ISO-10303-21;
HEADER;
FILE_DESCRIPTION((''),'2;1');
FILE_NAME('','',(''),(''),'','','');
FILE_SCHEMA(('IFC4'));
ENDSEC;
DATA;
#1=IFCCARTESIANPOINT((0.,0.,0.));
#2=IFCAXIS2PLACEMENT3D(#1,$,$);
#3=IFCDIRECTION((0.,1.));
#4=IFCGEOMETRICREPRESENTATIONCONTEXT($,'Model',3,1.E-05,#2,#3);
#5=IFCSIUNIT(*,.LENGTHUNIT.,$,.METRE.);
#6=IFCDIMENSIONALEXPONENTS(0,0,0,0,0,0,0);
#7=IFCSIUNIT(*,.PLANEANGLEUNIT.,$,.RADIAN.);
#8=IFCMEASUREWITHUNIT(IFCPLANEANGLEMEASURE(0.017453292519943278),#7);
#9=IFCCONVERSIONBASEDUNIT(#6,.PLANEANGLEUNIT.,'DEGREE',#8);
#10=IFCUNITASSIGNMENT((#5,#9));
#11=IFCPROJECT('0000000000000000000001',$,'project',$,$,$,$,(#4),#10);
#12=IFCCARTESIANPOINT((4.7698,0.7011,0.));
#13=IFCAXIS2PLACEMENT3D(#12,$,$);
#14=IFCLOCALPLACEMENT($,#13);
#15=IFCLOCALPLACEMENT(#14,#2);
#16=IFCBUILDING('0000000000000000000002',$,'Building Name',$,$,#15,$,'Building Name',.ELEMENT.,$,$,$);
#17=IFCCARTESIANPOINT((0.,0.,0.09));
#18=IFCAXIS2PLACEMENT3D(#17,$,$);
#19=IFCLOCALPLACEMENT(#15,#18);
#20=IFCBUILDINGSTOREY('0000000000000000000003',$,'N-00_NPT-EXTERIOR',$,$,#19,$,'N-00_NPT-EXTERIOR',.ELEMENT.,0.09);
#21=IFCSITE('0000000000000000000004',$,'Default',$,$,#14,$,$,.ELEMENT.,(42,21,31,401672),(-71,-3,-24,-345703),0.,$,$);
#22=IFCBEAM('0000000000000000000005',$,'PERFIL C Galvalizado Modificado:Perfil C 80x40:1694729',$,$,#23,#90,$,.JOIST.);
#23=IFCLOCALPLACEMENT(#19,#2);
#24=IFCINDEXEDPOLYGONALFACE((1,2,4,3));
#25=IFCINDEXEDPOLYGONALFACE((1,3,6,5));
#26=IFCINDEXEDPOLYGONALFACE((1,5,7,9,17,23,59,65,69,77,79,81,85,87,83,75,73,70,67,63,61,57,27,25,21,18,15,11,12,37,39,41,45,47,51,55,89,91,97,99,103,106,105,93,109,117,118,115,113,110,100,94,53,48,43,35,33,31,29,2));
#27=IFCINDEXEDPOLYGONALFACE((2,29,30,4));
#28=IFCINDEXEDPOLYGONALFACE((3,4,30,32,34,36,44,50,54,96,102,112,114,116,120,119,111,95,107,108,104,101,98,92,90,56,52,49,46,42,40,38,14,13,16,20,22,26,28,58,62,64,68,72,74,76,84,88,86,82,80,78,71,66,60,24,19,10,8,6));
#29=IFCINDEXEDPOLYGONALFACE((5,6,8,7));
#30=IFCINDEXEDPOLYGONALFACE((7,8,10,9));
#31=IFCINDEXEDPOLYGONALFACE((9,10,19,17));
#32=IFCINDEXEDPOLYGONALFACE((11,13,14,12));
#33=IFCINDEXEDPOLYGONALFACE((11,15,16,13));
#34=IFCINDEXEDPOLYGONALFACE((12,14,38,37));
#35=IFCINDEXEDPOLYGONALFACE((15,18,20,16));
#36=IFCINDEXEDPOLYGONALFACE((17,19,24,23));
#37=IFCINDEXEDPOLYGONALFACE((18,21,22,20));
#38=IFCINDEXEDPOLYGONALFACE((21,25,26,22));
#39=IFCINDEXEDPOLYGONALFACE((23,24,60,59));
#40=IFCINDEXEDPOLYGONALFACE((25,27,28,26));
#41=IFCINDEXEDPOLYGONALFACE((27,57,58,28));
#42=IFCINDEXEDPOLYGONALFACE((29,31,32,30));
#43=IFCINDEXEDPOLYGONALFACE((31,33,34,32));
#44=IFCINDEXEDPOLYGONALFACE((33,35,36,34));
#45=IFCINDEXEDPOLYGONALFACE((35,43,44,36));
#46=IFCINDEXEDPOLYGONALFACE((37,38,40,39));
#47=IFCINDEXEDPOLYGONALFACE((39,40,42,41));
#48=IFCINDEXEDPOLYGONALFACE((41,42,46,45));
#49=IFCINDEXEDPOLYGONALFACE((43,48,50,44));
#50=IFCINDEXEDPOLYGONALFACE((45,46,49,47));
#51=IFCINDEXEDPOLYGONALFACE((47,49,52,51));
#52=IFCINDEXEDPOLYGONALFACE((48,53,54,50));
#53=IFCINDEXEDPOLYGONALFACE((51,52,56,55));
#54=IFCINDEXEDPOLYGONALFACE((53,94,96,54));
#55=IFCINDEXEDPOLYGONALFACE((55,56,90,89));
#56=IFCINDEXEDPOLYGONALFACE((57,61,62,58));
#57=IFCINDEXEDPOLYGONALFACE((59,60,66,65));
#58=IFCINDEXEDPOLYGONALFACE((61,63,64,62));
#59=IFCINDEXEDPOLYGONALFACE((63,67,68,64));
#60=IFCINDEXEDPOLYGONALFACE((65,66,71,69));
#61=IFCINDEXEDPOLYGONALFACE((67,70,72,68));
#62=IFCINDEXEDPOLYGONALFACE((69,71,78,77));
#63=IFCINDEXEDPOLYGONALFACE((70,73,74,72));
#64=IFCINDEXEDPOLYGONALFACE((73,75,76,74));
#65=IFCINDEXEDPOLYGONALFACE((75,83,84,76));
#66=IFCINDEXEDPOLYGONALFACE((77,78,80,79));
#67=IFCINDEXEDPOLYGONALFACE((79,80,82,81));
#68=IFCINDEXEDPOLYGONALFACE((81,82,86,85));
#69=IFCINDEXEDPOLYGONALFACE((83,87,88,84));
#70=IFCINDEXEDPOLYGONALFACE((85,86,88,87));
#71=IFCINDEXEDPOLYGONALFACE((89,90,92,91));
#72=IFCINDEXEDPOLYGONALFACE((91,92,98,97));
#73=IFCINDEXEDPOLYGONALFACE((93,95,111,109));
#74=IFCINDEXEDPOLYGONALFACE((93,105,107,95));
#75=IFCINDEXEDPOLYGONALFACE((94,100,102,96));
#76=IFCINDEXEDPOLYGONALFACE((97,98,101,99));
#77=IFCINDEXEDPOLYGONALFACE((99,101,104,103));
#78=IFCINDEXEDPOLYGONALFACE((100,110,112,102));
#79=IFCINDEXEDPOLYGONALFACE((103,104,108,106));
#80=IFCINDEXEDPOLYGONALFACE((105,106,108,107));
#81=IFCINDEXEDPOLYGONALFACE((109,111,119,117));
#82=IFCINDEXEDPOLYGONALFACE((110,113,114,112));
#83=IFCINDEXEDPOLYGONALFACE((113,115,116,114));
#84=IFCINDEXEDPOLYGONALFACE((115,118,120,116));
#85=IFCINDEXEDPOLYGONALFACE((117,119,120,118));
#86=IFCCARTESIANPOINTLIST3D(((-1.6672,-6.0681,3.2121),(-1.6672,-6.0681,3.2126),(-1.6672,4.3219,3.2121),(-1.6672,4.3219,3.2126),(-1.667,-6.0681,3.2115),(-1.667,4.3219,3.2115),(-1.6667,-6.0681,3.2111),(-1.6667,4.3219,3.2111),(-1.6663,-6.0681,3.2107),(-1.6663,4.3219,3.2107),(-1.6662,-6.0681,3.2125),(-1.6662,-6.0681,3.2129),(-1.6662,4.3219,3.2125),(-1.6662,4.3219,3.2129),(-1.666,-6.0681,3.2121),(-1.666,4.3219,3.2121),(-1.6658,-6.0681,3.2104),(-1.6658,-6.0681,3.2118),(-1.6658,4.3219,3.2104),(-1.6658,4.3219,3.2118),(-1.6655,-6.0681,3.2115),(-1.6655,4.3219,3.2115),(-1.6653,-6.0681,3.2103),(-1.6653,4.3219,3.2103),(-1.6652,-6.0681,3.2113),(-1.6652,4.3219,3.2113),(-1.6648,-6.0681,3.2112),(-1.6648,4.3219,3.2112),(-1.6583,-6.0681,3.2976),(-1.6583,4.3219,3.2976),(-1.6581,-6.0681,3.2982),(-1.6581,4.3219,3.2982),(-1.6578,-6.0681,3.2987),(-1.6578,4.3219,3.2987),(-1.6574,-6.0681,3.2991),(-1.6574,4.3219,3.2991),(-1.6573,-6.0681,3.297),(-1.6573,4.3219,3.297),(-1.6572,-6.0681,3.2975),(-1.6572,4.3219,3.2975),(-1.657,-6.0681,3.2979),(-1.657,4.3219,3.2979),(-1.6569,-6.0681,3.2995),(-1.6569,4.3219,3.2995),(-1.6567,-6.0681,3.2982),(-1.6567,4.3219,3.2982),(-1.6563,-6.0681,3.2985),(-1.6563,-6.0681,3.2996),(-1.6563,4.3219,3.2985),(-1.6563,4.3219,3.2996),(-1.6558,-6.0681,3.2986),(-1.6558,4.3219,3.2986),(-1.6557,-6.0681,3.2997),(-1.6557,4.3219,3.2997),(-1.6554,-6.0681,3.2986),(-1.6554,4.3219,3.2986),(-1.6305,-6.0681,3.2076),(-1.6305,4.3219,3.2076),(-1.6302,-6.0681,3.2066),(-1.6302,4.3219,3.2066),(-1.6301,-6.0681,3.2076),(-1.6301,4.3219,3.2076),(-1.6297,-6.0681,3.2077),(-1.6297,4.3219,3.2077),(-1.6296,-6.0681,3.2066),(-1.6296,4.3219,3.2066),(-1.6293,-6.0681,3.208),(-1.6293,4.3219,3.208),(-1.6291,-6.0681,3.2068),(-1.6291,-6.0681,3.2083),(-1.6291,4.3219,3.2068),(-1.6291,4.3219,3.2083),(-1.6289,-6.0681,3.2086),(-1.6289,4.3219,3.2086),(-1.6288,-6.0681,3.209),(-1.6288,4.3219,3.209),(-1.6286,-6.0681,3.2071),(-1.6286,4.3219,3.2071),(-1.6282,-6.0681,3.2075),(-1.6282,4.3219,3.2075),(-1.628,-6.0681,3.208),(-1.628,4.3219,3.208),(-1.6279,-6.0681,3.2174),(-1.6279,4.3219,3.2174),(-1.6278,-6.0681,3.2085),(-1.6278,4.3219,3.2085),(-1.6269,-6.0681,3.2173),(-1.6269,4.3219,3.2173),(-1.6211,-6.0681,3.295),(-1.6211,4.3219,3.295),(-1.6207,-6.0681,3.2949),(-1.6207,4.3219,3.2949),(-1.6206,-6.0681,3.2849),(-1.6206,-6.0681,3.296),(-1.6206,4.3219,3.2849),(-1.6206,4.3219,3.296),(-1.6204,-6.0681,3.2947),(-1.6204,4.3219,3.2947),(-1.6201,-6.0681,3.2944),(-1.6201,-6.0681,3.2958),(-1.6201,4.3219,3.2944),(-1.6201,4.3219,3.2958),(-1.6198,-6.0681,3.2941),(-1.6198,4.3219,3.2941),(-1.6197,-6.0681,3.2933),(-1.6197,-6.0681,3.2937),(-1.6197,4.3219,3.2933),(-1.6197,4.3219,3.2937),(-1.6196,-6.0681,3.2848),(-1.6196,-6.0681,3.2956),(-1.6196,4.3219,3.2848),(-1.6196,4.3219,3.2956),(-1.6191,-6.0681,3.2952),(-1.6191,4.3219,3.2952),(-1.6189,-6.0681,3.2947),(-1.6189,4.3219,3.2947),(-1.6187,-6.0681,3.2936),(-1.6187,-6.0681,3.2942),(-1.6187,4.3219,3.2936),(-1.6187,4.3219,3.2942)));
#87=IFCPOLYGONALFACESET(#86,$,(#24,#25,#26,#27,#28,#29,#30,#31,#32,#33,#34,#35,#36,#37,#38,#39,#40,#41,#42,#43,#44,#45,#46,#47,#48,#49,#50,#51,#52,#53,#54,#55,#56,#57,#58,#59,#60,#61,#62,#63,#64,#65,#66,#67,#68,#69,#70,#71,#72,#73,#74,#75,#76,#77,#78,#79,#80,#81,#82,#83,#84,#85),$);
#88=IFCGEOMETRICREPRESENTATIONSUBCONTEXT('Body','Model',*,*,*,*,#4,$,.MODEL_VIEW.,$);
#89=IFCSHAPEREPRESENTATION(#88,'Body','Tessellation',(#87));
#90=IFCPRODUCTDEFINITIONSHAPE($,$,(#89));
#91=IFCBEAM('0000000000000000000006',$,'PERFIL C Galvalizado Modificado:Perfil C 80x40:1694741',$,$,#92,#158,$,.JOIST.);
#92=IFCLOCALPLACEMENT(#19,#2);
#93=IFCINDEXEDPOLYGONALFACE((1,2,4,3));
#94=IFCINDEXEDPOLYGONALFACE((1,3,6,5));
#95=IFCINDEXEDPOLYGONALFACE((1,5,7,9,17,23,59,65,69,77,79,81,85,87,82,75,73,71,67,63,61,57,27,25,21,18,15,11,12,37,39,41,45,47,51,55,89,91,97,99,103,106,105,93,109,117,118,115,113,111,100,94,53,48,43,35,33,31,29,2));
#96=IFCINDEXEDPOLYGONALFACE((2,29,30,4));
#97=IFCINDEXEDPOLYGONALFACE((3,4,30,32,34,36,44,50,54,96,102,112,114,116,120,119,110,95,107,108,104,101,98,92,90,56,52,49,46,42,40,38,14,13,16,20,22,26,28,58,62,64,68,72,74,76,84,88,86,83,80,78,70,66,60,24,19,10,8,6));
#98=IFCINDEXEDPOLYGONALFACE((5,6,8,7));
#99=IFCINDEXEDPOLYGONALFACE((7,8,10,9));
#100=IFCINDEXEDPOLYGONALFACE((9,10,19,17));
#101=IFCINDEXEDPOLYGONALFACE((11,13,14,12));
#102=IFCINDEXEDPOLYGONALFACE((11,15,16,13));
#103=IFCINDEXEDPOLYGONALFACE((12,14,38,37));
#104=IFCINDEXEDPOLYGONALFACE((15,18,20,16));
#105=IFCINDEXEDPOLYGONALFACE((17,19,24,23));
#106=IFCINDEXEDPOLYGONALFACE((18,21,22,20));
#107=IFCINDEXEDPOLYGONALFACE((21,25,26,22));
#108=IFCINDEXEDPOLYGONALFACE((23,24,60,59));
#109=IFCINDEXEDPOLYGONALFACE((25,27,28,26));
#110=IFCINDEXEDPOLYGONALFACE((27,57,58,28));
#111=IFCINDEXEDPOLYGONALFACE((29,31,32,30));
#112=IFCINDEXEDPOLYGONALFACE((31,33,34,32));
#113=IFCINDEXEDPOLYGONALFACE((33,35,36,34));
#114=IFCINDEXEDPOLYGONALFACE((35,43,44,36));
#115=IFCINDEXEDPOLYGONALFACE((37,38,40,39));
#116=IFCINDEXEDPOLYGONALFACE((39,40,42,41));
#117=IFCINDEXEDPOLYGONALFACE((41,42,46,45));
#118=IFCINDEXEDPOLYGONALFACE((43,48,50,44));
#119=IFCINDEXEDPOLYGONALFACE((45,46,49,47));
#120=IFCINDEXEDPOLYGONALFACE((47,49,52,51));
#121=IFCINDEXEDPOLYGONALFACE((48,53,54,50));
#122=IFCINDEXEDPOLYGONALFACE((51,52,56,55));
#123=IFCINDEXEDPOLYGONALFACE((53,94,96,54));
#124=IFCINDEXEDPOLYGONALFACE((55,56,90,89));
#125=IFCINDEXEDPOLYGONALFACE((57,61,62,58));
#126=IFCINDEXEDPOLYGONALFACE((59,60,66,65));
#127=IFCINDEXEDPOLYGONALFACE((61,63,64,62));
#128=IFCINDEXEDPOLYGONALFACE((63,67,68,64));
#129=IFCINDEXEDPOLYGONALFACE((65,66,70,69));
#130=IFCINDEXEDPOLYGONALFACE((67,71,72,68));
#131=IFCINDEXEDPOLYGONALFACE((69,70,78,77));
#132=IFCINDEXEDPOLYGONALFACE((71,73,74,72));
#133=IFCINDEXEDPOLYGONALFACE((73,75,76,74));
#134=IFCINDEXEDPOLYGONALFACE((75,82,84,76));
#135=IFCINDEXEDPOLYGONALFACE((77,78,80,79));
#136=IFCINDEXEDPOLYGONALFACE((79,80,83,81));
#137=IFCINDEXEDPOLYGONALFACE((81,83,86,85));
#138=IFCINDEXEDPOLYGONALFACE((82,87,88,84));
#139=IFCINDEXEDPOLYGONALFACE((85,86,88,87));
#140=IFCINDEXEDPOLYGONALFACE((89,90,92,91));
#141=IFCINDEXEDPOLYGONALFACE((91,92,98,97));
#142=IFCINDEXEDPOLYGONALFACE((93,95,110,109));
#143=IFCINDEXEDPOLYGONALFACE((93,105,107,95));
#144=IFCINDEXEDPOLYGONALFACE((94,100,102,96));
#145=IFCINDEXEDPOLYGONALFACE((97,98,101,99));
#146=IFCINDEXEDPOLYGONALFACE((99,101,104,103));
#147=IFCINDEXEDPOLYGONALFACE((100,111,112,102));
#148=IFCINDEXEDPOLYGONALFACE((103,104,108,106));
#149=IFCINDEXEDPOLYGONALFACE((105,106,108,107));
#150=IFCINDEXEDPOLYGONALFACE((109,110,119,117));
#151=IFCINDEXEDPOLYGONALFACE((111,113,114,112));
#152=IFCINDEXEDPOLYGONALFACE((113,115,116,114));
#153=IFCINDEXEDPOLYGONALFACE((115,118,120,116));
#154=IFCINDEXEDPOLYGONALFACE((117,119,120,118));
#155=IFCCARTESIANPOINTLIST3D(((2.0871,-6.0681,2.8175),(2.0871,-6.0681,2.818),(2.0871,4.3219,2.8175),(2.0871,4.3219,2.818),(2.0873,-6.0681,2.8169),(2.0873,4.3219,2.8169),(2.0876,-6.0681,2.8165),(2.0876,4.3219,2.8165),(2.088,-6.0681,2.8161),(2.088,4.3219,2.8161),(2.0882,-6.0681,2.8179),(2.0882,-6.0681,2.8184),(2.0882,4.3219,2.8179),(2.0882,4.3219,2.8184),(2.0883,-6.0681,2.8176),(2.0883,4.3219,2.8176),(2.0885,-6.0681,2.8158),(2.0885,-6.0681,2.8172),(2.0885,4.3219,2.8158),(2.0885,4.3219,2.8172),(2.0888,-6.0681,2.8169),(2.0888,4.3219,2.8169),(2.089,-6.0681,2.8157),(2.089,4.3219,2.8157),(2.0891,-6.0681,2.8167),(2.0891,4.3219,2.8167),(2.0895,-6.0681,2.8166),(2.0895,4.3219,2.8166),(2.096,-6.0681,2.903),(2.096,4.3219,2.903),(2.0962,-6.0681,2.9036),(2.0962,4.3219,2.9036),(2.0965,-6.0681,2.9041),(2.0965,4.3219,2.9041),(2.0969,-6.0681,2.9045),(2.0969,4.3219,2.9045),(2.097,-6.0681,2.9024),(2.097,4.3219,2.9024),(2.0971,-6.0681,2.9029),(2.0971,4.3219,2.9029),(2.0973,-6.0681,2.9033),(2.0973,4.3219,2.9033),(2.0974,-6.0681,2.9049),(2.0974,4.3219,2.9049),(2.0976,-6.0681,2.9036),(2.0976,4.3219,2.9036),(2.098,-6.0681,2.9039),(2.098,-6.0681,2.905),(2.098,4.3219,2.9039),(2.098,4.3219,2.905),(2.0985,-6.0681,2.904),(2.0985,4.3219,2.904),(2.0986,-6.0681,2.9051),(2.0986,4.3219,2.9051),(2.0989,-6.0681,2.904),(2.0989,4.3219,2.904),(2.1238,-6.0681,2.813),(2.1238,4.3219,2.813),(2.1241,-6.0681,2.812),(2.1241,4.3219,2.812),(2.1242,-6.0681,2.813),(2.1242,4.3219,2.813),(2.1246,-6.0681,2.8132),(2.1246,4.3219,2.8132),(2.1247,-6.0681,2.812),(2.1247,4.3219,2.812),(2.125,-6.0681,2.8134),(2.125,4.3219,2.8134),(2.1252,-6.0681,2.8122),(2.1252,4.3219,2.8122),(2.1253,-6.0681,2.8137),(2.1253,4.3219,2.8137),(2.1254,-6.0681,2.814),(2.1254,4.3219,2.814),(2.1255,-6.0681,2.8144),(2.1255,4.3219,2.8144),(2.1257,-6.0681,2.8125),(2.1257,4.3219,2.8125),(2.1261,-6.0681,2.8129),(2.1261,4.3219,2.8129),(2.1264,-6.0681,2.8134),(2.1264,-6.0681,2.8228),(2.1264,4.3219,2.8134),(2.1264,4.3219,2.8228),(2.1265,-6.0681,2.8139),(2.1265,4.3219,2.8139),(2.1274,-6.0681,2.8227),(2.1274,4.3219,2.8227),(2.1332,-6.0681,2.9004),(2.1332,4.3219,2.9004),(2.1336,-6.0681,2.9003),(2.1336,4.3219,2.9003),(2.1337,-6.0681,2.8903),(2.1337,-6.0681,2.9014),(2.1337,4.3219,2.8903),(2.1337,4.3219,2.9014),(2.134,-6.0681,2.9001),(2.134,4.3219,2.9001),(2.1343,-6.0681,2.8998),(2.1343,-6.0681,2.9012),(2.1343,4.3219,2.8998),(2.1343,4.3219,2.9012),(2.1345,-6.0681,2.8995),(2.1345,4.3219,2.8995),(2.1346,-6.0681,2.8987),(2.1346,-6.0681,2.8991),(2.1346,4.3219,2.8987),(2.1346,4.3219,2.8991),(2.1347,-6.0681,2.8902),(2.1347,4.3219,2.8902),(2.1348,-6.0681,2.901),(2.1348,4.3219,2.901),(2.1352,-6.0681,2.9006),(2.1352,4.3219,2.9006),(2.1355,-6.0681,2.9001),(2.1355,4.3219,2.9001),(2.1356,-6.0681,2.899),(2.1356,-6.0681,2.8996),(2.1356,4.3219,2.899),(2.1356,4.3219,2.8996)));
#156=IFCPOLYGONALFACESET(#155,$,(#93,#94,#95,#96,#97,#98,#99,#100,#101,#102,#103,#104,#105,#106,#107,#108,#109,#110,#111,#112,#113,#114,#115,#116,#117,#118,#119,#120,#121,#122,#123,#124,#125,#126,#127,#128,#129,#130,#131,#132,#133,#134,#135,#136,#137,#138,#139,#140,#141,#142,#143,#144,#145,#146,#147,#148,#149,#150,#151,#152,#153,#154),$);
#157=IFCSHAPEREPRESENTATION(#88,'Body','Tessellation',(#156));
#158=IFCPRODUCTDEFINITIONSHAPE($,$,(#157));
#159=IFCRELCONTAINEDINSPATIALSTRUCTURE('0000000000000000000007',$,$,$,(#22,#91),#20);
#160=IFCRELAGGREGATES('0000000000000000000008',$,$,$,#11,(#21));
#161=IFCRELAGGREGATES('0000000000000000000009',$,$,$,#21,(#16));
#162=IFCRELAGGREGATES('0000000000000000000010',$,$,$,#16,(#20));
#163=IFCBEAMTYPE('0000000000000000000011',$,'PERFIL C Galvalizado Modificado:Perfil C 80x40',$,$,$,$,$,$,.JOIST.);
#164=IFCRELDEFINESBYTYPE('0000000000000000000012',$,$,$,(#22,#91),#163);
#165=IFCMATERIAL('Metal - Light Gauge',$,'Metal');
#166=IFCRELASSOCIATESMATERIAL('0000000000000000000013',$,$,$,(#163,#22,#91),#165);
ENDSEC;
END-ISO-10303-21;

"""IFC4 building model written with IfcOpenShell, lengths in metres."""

from ifc_helpers import new_model, entity, si_unit, converted_unit, direction, frame, origin, place, context, subcontext, project, spatial, line, arc, indexed_curve, outline, extrude, source, transform, mapped, material, type_object, type_shapes, element, save


model = new_model("IFC4")

# Units and contexts
model_context = context("Model", 3, precision=1e-05, world=origin(), true_north=direction((0.0, 1.0)))
body_context = subcontext(model_context, "Body", "Model", "MODEL_VIEW")
ifc_project = project(units=[si_unit("LENGTHUNIT", "METRE"), converted_unit("PLANEANGLEUNIT", "DEGREE", entity("IfcPlaneAngleMeasure", 0.017453292519943278), si_unit("PLANEANGLEUNIT", "RADIAN"), dimensions=[0, 0, 0, 0, 0, 0, 0])], contexts=[model_context])

# Site, building, storey
site_placement = place(None, frame((4.7698, 0.7011, 0.0)))
site = spatial("IfcSite", under=ifc_project, at=site_placement, Name="Default", CompositionType="ELEMENT", RefLatitude=(42, 21, 31, 401672), RefLongitude=(-71, -3, -24, -345703), RefElevation=0.0)
building_placement = place(site_placement, origin())
building = spatial("IfcBuilding", under=site, at=building_placement, Name="Building Name", LongName="Building Name", CompositionType="ELEMENT")
storey_placement = place(building_placement, frame((0.0, 0.0, 0.09)))
storey = spatial("IfcBuildingStorey", under=building, at=storey_placement, Name="N-00_NPT-EXTERIOR", LongName="N-00_NPT-EXTERIOR", CompositionType="ELEMENT", Elevation=0.09)

# Beams
ifc_material_1 = material(Name="Metal - Light Gauge", Category="Metal")
beam_type_1 = type_object("IfcBeamType", Name="PERFIL C Galvalizado Modificado:Perfil C 80x40", PredefinedType="JOIST", material=ifc_material_1)
shared_shape_1 = source(origin(), body_context, "Body", "SweptSolid", [
    extrude(outline(indexed_curve([(-0.0428, -0.0161), (-0.034, -0.0161), (-0.034, -0.0151), (-0.0424, -0.0151), (-0.0435, -0.0146), (-0.044, -0.0135), (-0.044, 0.021), (-0.0435, 0.0222), (-0.0422, 0.0227), (0.0424, 0.0227), (0.0435, 0.0223), (0.0439, 0.0212), (0.0439, -0.0133), (0.0435, -0.0144), (0.0424, -0.0149), (0.0339, -0.0149), (0.0339, -0.0159), (0.0428, -0.0159), (0.0443, -0.0152), (0.0449, -0.0137), (0.0449, 0.0216), (0.0443, 0.0231), (0.0428, 0.0237), (-0.0426, 0.0237), (-0.0443, 0.023), (-0.045, 0.0214), (-0.045, -0.0139), (-0.0443, -0.0154)], segments=[line(1, 2, 3, 4), arc(4, 5, 6), line(6, 7), arc(7, 8, 9), line(9, 10), arc(10, 11, 12), line(12, 13), arc(13, 14, 15), line(15, 16, 17, 18), arc(18, 19, 20), line(20, 21), arc(21, 22, 23), line(23, 24), arc(24, 25, 26), line(26, 27), arc(27, 28, 1)], self_intersect=False)), frame((-5.195, -0.0037, 0.0), z_axis=(1.0, 0.0, 0.0), x_axis=(0.0, 0.0, -1.0)), (0.0, 0.0, 1.0), 10.39),
])
type_shapes(beam_type_1, [shared_shape_1])
for number, where, z_axis, x_axis, name in (
    (1, (-1.6428, -0.8731, 3.2531), (0.104528, 0.0, 0.994522), (0.0, 1.0, 0.0), "PERFIL C Galvalizado Modificado:Perfil C 80x40:1694729"),
    (2, (2.1115, -0.8731, 2.8585), (0.104528, 0.0, 0.994522), (0.0, 1.0, 0.0), "PERFIL C Galvalizado Modificado:Perfil C 80x40:1694741"),
):
    element("IfcBeam", number, at=place(storey_placement, frame(where, z_axis=z_axis, x_axis=x_axis)), inside=storey, type_object=beam_type_1, material=ifc_material_1, Name=name, PredefinedType="JOIST", context=body_context, shape_type="MappedRepresentation", body=[
        mapped(shared_shape_1, transform((0.0, 0.0, 0.0), scale=1.0)),
    ])

save(model, "model.ifc")
